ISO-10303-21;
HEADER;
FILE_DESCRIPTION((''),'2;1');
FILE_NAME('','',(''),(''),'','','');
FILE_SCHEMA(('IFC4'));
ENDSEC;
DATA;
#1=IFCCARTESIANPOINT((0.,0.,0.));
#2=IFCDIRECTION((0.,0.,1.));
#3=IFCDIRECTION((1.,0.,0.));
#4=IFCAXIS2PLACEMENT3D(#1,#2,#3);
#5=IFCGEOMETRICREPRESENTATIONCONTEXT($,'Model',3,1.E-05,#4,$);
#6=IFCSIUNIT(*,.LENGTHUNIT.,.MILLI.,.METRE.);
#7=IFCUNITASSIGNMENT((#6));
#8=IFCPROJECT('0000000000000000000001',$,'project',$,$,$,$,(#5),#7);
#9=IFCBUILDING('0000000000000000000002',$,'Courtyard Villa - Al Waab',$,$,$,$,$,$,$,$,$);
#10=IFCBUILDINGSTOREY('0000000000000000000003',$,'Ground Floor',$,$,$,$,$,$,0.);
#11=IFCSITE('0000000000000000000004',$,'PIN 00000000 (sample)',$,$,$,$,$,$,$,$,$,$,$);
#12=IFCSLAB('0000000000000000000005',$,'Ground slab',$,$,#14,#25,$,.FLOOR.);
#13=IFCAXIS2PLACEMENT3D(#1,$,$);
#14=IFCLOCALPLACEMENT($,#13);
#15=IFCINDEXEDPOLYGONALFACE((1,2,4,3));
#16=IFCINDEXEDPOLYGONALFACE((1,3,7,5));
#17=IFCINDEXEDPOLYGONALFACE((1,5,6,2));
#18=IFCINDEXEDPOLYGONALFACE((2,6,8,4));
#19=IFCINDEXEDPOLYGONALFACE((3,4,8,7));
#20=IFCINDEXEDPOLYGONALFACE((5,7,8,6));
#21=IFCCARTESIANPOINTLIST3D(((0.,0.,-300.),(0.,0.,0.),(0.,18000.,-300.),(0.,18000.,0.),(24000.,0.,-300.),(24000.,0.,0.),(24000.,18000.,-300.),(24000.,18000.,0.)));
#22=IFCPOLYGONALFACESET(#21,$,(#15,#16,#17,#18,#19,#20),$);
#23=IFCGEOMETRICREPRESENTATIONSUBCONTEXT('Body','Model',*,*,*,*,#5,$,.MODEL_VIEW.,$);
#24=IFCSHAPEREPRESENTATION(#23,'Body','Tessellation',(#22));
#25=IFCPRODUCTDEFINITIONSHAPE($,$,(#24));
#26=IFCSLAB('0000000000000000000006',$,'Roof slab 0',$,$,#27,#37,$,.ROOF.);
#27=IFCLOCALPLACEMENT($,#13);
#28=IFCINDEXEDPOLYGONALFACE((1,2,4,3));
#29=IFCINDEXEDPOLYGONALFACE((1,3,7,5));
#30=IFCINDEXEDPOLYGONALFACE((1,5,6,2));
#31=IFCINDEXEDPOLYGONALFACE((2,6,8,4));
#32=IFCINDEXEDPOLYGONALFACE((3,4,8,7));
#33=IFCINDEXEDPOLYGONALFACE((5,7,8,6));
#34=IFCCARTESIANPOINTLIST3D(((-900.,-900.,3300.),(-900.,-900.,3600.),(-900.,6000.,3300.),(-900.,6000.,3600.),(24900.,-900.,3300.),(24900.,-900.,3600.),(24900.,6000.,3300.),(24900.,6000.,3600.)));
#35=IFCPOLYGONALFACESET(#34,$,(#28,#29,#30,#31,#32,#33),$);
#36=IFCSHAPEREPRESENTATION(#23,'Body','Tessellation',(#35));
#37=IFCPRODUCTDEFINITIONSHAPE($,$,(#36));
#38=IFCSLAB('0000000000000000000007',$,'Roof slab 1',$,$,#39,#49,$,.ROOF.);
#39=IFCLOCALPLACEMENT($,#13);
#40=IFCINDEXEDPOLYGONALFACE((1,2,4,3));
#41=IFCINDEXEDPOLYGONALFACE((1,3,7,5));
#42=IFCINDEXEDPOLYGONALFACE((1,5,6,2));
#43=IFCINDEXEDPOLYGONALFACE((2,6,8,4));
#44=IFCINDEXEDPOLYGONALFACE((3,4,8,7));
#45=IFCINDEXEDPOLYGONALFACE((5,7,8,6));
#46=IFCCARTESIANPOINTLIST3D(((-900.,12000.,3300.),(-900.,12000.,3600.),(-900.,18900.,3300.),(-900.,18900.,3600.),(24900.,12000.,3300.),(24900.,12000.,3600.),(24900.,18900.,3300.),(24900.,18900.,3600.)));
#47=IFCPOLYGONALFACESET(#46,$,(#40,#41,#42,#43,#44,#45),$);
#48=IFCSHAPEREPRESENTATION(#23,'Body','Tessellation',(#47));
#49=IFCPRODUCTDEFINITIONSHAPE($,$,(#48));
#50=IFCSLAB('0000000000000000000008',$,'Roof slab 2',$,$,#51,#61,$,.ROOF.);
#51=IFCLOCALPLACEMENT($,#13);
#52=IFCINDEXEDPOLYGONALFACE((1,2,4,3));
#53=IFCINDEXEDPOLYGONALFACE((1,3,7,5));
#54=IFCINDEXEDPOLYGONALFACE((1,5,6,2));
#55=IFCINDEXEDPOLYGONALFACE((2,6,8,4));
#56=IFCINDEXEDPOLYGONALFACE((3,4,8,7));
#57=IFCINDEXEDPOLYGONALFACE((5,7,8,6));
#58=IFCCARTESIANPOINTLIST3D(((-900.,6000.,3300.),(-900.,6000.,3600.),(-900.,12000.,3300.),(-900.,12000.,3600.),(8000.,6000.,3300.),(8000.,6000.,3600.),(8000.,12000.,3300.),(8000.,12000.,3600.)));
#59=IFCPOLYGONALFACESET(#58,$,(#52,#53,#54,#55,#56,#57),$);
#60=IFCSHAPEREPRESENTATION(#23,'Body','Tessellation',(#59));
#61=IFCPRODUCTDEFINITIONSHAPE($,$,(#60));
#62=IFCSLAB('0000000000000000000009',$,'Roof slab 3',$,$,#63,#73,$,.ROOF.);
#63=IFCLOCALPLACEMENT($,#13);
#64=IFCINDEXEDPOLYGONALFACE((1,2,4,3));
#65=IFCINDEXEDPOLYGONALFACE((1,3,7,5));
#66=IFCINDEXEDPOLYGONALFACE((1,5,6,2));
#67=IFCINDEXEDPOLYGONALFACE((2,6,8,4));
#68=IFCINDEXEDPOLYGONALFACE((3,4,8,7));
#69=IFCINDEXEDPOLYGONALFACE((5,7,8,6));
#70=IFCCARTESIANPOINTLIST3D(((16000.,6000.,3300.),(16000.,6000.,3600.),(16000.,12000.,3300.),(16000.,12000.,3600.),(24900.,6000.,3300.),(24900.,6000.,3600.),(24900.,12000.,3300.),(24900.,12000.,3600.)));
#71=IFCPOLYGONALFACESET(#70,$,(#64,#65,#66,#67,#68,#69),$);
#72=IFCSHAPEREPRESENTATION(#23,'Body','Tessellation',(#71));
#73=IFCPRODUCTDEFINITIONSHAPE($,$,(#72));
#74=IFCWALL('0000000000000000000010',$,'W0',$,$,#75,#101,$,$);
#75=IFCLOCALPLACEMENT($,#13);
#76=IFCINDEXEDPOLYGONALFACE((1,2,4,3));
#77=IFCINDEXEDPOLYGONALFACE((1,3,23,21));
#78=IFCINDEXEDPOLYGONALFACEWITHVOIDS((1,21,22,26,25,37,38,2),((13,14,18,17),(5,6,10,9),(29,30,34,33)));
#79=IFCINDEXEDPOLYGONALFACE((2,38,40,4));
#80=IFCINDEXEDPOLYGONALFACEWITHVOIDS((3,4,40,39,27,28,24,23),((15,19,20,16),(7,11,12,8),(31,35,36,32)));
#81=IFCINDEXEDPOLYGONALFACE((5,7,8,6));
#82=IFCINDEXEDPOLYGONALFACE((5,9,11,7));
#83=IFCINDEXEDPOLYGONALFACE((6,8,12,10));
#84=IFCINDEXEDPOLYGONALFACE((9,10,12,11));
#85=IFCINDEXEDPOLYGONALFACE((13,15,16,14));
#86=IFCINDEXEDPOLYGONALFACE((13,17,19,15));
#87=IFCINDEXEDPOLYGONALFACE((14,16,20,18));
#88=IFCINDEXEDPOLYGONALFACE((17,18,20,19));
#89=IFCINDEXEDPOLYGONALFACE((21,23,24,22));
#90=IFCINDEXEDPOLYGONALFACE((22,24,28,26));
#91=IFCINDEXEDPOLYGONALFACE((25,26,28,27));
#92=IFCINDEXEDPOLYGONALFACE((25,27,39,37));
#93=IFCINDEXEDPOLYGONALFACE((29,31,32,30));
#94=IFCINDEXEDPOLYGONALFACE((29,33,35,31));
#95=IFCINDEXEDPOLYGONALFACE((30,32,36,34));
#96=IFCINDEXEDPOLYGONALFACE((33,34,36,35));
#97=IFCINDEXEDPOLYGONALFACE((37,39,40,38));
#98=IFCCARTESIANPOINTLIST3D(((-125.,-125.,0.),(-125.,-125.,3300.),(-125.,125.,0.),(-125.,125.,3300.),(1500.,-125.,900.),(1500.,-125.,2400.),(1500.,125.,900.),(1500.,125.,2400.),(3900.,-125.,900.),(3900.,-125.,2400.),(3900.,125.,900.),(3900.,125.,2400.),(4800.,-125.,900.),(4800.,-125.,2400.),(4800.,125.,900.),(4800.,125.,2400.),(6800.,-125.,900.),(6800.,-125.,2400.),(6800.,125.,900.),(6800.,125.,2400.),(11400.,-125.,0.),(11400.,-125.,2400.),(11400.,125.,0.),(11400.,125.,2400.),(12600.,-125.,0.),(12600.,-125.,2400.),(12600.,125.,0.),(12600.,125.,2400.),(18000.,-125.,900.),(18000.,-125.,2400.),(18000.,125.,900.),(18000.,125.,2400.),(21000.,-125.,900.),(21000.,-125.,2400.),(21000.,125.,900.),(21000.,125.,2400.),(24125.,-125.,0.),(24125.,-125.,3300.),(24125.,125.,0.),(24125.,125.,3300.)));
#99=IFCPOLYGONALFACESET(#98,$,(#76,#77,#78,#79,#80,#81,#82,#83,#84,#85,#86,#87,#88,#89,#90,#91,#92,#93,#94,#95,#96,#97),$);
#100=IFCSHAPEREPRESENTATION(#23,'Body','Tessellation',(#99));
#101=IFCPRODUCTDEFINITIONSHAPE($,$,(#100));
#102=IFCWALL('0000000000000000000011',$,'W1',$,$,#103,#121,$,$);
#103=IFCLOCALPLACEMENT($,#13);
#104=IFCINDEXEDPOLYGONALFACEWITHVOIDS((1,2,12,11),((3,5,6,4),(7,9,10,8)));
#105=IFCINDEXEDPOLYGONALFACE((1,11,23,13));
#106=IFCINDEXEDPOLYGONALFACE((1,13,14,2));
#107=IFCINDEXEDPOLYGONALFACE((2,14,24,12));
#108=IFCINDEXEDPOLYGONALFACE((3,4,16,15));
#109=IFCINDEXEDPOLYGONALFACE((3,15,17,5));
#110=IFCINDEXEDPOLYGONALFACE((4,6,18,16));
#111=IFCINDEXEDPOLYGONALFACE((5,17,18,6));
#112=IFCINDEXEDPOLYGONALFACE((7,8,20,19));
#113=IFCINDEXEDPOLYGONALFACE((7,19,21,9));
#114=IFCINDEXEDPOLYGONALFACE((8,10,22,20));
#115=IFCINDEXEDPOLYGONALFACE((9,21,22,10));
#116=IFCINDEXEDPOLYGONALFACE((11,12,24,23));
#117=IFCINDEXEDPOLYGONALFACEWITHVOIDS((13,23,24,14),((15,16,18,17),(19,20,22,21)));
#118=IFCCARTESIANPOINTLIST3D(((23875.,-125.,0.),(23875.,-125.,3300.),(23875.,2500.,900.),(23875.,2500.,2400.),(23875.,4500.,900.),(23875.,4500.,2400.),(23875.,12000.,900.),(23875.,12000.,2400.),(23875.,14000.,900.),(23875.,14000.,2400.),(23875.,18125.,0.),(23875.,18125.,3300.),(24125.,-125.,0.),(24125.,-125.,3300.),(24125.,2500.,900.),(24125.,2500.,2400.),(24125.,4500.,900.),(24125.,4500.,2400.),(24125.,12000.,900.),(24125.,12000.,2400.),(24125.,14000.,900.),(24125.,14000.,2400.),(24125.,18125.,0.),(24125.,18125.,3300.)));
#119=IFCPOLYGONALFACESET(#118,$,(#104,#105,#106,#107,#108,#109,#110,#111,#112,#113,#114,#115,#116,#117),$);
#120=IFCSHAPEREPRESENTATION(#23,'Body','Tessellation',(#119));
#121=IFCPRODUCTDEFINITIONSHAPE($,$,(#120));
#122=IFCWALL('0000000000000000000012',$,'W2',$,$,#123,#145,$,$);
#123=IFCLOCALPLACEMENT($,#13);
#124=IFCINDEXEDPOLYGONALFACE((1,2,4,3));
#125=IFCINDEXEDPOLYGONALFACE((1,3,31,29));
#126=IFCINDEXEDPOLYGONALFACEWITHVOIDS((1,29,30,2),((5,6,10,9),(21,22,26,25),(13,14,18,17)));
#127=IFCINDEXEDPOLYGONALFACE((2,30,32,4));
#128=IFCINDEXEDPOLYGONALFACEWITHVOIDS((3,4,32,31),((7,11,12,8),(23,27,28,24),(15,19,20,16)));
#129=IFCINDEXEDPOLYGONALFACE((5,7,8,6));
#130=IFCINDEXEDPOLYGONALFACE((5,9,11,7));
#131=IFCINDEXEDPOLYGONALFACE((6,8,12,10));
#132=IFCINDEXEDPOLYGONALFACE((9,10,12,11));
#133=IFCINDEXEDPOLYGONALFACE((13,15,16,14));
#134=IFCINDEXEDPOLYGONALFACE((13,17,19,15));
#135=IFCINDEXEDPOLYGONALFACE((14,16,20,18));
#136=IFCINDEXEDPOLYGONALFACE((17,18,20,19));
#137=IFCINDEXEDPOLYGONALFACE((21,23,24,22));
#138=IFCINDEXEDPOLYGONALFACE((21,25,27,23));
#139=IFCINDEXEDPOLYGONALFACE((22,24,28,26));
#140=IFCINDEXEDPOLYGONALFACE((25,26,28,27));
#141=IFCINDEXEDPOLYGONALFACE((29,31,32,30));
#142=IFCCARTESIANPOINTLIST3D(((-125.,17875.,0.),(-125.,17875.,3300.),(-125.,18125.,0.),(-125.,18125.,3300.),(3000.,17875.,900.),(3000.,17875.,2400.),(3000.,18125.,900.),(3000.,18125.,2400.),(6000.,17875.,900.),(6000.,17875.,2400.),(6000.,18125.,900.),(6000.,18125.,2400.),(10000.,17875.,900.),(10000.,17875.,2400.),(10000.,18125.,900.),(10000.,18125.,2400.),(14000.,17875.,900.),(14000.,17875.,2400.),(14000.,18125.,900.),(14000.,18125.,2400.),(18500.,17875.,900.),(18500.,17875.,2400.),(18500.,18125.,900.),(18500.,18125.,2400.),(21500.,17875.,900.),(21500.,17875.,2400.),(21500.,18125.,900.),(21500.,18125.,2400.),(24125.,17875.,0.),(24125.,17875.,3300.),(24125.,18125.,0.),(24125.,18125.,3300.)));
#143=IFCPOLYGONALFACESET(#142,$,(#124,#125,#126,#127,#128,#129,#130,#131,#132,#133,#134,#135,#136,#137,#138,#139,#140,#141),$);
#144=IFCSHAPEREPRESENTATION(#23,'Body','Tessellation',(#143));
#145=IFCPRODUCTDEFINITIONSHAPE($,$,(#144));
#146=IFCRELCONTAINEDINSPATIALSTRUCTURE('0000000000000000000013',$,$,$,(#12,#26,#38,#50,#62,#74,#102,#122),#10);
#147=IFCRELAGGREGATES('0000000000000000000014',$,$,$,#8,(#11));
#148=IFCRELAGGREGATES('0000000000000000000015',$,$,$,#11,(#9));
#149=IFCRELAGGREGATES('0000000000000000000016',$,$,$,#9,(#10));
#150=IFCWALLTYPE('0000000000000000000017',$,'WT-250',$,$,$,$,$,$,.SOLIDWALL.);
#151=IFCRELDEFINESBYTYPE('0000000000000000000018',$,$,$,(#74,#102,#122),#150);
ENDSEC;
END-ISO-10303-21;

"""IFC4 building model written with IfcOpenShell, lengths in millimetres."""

from ifc_helpers import new_model, si_unit, frame, origin_with_axes, place, context, subcontext, project, spatial, indexed_curve, outline, extrude, type_object, element, save


model = new_model("IFC4")

# Units and contexts
model_context = context("Model", 3, precision=1e-05, world=origin_with_axes())
body_context = subcontext(model_context, "Body", "Model", "MODEL_VIEW")
ifc_project = project(units=[si_unit("LENGTHUNIT", "METRE", prefix="MILLI")], contexts=[model_context])

# Site, building, storey
site = spatial("IfcSite", under=ifc_project, Name="PIN 00000000 (sample)")
building = spatial("IfcBuilding", under=site, Name="Courtyard Villa - Al Waab")
storey = spatial("IfcBuildingStorey", under=building, Name="Ground Floor", Elevation=0.0)

# Slabs
slab_1_placement = place(None, frame((0.0, 0.0, -300.0), z_axis=(0.0, 0.0, 1.0), x_axis=(1.0, 0.0, 0.0)))
element("IfcSlab", 1, at=slab_1_placement, inside=storey, Name="Ground slab", PredefinedType="FLOOR", context=body_context, shape_type="SweptSolid", body=[
    extrude(outline(indexed_curve([(0.0, 0.0), (24000.0, 0.0), (24000.0, 18000.0), (0.0, 18000.0)])), None, (0.0, 0.0, 1.0), 300.0),
])
slab_2_placement = place(None, frame((0.0, 0.0, 3300.0), z_axis=(0.0, 0.0, 1.0), x_axis=(1.0, 0.0, 0.0)))
element("IfcSlab", 2, at=slab_2_placement, inside=storey, Name="Roof slab 0", PredefinedType="ROOF", context=body_context, shape_type="SweptSolid", body=[
    extrude(outline(indexed_curve([(-900.0, -900.0), (24900.0, -900.0), (24900.0, 6000.0), (-900.0, 6000.0)])), None, (0.0, 0.0, 1.0), 300.0),
])
slab_3_placement = place(None, frame((0.0, 0.0, 3300.0), z_axis=(0.0, 0.0, 1.0), x_axis=(1.0, 0.0, 0.0)))
element("IfcSlab", 3, at=slab_3_placement, inside=storey, Name="Roof slab 1", PredefinedType="ROOF", context=body_context, shape_type="SweptSolid", body=[
    extrude(outline(indexed_curve([(-900.0, 12000.0), (24900.0, 12000.0), (24900.0, 18900.0), (-900.0, 18900.0)])), None, (0.0, 0.0, 1.0), 300.0),
])
slab_4_placement = place(None, frame((0.0, 0.0, 3300.0), z_axis=(0.0, 0.0, 1.0), x_axis=(1.0, 0.0, 0.0)))
element("IfcSlab", 4, at=slab_4_placement, inside=storey, Name="Roof slab 2", PredefinedType="ROOF", context=body_context, shape_type="SweptSolid", body=[
    extrude(outline(indexed_curve([(-900.0, 6000.0), (8000.0, 6000.0), (8000.0, 12000.0), (-900.0, 12000.0)])), None, (0.0, 0.0, 1.0), 300.0),
])
slab_5_placement = place(None, frame((0.0, 0.0, 3300.0), z_axis=(0.0, 0.0, 1.0), x_axis=(1.0, 0.0, 0.0)))
element("IfcSlab", 5, at=slab_5_placement, inside=storey, Name="Roof slab 3", PredefinedType="ROOF", context=body_context, shape_type="SweptSolid", body=[
    extrude(outline(indexed_curve([(16000.0, 6000.0), (24900.0, 6000.0), (24900.0, 12000.0), (16000.0, 12000.0)])), None, (0.0, 0.0, 1.0), 300.0),
])

# Walls, openings
wall_type_1 = type_object("IfcWallType", Name="WT-250", PredefinedType="SOLIDWALL")
wall_1_placement = place(None, frame((-125.0, -125.0, 0.0), z_axis=(0.0, 0.0, 1.0), x_axis=(1.0, 0.0, 0.0)))
wall_1 = element("IfcWall", 6, at=wall_1_placement, inside=storey, type_object=wall_type_1, Name="W0", context=body_context, shape_type="SweptSolid", body=[
    extrude(outline(indexed_curve([(0.0, 0.0), (0.0, 250.0), (24250.0, 250.0), (24250.0, 0.0), (0.0, 0.0)], self_intersect=False)), origin_with_axes(), (0.0, 0.0, 1.0), 3300.0),
])
opening_1_placement = place(wall_1_placement, frame((1625.0, -100.0, 900.0), z_axis=(0.0, 0.0, 1.0), x_axis=(1.0, 0.0, 0.0)))
element("IfcOpeningElement", 7, at=opening_1_placement, cuts=wall_1, context=body_context, shape_type="SweptSolid", body=[
    extrude(outline(indexed_curve([(0.0, 0.0), (0.0, 450.0), (2400.0, 450.0), (2400.0, 0.0), (0.0, 0.0)], self_intersect=False)), origin_with_axes(), (0.0, 0.0, 1.0), 1500.0),
])
opening_2_placement = place(wall_1_placement, frame((4925.0, -100.0, 900.0), z_axis=(0.0, 0.0, 1.0), x_axis=(1.0, 0.0, 0.0)))
element("IfcOpeningElement", 8, at=opening_2_placement, cuts=wall_1, context=body_context, shape_type="SweptSolid", body=[
    extrude(outline(indexed_curve([(0.0, 0.0), (0.0, 450.0), (2000.0, 450.0), (2000.0, 0.0), (0.0, 0.0)], self_intersect=False)), origin_with_axes(), (0.0, 0.0, 1.0), 1500.0),
])
opening_3_placement = place(wall_1_placement, frame((11525.0, -100.0, 0.0), z_axis=(0.0, 0.0, 1.0), x_axis=(1.0, 0.0, 0.0)))
element("IfcOpeningElement", 9, at=opening_3_placement, cuts=wall_1, context=body_context, shape_type="SweptSolid", body=[
    extrude(outline(indexed_curve([(0.0, 0.0), (0.0, 450.0), (1200.0, 450.0), (1200.0, 0.0), (0.0, 0.0)], self_intersect=False)), origin_with_axes(), (0.0, 0.0, 1.0), 2400.0),
])
opening_4_placement = place(wall_1_placement, frame((18125.0, -100.0, 900.0), z_axis=(0.0, 0.0, 1.0), x_axis=(1.0, 0.0, 0.0)))
element("IfcOpeningElement", 10, at=opening_4_placement, cuts=wall_1, context=body_context, shape_type="SweptSolid", body=[
    extrude(outline(indexed_curve([(0.0, 0.0), (0.0, 450.0), (3000.0, 450.0), (3000.0, 0.0), (0.0, 0.0)], self_intersect=False)), origin_with_axes(), (0.0, 0.0, 1.0), 1500.0),
])
wall_2_placement = place(None, frame((24125.0, -125.0, 0.0), z_axis=(0.0, 0.0, 1.0), x_axis=(0.0, 1.0, 0.0)))
wall_2 = element("IfcWall", 11, at=wall_2_placement, inside=storey, type_object=wall_type_1, Name="W1", context=body_context, shape_type="SweptSolid", body=[
    extrude(outline(indexed_curve([(0.0, 0.0), (0.0, 250.0), (18250.0, 250.0), (18250.0, 0.0), (0.0, 0.0)], self_intersect=False)), origin_with_axes(), (0.0, 0.0, 1.0), 3300.0),
])
opening_5_placement = place(wall_2_placement, frame((2625.0, -100.0, 900.0), z_axis=(0.0, 0.0, 1.0), x_axis=(1.0, 0.0, 0.0)))
element("IfcOpeningElement", 12, at=opening_5_placement, cuts=wall_2, context=body_context, shape_type="SweptSolid", body=[
    extrude(outline(indexed_curve([(0.0, 0.0), (0.0, 450.0), (2000.0, 450.0), (2000.0, 0.0), (0.0, 0.0)], self_intersect=False)), origin_with_axes(), (0.0, 0.0, 1.0), 1500.0),
])
opening_6_placement = place(wall_2_placement, frame((12125.0, -100.0, 900.0), z_axis=(0.0, 0.0, 1.0), x_axis=(1.0, 0.0, 0.0)))
element("IfcOpeningElement", 13, at=opening_6_placement, cuts=wall_2, context=body_context, shape_type="SweptSolid", body=[
    extrude(outline(indexed_curve([(0.0, 0.0), (0.0, 450.0), (2000.0, 450.0), (2000.0, 0.0), (0.0, 0.0)], self_intersect=False)), origin_with_axes(), (0.0, 0.0, 1.0), 1500.0),
])
wall_3_placement = place(None, frame((24125.0, 18125.0, 0.0), z_axis=(0.0, 0.0, 1.0), x_axis=(-1.0, 0.0, 0.0)))
wall_3 = element("IfcWall", 14, at=wall_3_placement, inside=storey, type_object=wall_type_1, Name="W2", context=body_context, shape_type="SweptSolid", body=[
    extrude(outline(indexed_curve([(0.0, 0.0), (0.0, 250.0), (24250.0, 250.0), (24250.0, 0.0), (0.0, 0.0)], self_intersect=False)), origin_with_axes(), (0.0, 0.0, 1.0), 3300.0),
])
opening_7_placement = place(wall_3_placement, frame((2625.0, -100.0, 900.0), z_axis=(0.0, 0.0, 1.0), x_axis=(1.0, 0.0, 0.0)))
element("IfcOpeningElement", 15, at=opening_7_placement, cuts=wall_3, context=body_context, shape_type="SweptSolid", body=[
    extrude(outline(indexed_curve([(0.0, 0.0), (0.0, 450.0), (3000.0, 450.0), (3000.0, 0.0), (0.0, 0.0)], self_intersect=False)), origin_with_axes(), (0.0, 0.0, 1.0), 1500.0),
])
opening_8_placement = place(wall_3_placement, frame((10125.0, -100.0, 900.0), z_axis=(0.0, 0.0, 1.0), x_axis=(1.0, 0.0, 0.0)))
element("IfcOpeningElement", 16, at=opening_8_placement, cuts=wall_3, context=body_context, shape_type="SweptSolid", body=[
    extrude(outline(indexed_curve([(0.0, 0.0), (0.0, 450.0), (4000.0, 450.0), (4000.0, 0.0), (0.0, 0.0)], self_intersect=False)), origin_with_axes(), (0.0, 0.0, 1.0), 1500.0),
])
opening_9_placement = place(wall_3_placement, frame((18125.0, -100.0, 900.0), z_axis=(0.0, 0.0, 1.0), x_axis=(1.0, 0.0, 0.0)))
element("IfcOpeningElement", 17, at=opening_9_placement, cuts=wall_3, context=body_context, shape_type="SweptSolid", body=[
    extrude(outline(indexed_curve([(0.0, 0.0), (0.0, 450.0), (3000.0, 450.0), (3000.0, 0.0), (0.0, 0.0)], self_intersect=False)), origin_with_axes(), (0.0, 0.0, 1.0), 1500.0),
])

save(model, "model.ifc")
